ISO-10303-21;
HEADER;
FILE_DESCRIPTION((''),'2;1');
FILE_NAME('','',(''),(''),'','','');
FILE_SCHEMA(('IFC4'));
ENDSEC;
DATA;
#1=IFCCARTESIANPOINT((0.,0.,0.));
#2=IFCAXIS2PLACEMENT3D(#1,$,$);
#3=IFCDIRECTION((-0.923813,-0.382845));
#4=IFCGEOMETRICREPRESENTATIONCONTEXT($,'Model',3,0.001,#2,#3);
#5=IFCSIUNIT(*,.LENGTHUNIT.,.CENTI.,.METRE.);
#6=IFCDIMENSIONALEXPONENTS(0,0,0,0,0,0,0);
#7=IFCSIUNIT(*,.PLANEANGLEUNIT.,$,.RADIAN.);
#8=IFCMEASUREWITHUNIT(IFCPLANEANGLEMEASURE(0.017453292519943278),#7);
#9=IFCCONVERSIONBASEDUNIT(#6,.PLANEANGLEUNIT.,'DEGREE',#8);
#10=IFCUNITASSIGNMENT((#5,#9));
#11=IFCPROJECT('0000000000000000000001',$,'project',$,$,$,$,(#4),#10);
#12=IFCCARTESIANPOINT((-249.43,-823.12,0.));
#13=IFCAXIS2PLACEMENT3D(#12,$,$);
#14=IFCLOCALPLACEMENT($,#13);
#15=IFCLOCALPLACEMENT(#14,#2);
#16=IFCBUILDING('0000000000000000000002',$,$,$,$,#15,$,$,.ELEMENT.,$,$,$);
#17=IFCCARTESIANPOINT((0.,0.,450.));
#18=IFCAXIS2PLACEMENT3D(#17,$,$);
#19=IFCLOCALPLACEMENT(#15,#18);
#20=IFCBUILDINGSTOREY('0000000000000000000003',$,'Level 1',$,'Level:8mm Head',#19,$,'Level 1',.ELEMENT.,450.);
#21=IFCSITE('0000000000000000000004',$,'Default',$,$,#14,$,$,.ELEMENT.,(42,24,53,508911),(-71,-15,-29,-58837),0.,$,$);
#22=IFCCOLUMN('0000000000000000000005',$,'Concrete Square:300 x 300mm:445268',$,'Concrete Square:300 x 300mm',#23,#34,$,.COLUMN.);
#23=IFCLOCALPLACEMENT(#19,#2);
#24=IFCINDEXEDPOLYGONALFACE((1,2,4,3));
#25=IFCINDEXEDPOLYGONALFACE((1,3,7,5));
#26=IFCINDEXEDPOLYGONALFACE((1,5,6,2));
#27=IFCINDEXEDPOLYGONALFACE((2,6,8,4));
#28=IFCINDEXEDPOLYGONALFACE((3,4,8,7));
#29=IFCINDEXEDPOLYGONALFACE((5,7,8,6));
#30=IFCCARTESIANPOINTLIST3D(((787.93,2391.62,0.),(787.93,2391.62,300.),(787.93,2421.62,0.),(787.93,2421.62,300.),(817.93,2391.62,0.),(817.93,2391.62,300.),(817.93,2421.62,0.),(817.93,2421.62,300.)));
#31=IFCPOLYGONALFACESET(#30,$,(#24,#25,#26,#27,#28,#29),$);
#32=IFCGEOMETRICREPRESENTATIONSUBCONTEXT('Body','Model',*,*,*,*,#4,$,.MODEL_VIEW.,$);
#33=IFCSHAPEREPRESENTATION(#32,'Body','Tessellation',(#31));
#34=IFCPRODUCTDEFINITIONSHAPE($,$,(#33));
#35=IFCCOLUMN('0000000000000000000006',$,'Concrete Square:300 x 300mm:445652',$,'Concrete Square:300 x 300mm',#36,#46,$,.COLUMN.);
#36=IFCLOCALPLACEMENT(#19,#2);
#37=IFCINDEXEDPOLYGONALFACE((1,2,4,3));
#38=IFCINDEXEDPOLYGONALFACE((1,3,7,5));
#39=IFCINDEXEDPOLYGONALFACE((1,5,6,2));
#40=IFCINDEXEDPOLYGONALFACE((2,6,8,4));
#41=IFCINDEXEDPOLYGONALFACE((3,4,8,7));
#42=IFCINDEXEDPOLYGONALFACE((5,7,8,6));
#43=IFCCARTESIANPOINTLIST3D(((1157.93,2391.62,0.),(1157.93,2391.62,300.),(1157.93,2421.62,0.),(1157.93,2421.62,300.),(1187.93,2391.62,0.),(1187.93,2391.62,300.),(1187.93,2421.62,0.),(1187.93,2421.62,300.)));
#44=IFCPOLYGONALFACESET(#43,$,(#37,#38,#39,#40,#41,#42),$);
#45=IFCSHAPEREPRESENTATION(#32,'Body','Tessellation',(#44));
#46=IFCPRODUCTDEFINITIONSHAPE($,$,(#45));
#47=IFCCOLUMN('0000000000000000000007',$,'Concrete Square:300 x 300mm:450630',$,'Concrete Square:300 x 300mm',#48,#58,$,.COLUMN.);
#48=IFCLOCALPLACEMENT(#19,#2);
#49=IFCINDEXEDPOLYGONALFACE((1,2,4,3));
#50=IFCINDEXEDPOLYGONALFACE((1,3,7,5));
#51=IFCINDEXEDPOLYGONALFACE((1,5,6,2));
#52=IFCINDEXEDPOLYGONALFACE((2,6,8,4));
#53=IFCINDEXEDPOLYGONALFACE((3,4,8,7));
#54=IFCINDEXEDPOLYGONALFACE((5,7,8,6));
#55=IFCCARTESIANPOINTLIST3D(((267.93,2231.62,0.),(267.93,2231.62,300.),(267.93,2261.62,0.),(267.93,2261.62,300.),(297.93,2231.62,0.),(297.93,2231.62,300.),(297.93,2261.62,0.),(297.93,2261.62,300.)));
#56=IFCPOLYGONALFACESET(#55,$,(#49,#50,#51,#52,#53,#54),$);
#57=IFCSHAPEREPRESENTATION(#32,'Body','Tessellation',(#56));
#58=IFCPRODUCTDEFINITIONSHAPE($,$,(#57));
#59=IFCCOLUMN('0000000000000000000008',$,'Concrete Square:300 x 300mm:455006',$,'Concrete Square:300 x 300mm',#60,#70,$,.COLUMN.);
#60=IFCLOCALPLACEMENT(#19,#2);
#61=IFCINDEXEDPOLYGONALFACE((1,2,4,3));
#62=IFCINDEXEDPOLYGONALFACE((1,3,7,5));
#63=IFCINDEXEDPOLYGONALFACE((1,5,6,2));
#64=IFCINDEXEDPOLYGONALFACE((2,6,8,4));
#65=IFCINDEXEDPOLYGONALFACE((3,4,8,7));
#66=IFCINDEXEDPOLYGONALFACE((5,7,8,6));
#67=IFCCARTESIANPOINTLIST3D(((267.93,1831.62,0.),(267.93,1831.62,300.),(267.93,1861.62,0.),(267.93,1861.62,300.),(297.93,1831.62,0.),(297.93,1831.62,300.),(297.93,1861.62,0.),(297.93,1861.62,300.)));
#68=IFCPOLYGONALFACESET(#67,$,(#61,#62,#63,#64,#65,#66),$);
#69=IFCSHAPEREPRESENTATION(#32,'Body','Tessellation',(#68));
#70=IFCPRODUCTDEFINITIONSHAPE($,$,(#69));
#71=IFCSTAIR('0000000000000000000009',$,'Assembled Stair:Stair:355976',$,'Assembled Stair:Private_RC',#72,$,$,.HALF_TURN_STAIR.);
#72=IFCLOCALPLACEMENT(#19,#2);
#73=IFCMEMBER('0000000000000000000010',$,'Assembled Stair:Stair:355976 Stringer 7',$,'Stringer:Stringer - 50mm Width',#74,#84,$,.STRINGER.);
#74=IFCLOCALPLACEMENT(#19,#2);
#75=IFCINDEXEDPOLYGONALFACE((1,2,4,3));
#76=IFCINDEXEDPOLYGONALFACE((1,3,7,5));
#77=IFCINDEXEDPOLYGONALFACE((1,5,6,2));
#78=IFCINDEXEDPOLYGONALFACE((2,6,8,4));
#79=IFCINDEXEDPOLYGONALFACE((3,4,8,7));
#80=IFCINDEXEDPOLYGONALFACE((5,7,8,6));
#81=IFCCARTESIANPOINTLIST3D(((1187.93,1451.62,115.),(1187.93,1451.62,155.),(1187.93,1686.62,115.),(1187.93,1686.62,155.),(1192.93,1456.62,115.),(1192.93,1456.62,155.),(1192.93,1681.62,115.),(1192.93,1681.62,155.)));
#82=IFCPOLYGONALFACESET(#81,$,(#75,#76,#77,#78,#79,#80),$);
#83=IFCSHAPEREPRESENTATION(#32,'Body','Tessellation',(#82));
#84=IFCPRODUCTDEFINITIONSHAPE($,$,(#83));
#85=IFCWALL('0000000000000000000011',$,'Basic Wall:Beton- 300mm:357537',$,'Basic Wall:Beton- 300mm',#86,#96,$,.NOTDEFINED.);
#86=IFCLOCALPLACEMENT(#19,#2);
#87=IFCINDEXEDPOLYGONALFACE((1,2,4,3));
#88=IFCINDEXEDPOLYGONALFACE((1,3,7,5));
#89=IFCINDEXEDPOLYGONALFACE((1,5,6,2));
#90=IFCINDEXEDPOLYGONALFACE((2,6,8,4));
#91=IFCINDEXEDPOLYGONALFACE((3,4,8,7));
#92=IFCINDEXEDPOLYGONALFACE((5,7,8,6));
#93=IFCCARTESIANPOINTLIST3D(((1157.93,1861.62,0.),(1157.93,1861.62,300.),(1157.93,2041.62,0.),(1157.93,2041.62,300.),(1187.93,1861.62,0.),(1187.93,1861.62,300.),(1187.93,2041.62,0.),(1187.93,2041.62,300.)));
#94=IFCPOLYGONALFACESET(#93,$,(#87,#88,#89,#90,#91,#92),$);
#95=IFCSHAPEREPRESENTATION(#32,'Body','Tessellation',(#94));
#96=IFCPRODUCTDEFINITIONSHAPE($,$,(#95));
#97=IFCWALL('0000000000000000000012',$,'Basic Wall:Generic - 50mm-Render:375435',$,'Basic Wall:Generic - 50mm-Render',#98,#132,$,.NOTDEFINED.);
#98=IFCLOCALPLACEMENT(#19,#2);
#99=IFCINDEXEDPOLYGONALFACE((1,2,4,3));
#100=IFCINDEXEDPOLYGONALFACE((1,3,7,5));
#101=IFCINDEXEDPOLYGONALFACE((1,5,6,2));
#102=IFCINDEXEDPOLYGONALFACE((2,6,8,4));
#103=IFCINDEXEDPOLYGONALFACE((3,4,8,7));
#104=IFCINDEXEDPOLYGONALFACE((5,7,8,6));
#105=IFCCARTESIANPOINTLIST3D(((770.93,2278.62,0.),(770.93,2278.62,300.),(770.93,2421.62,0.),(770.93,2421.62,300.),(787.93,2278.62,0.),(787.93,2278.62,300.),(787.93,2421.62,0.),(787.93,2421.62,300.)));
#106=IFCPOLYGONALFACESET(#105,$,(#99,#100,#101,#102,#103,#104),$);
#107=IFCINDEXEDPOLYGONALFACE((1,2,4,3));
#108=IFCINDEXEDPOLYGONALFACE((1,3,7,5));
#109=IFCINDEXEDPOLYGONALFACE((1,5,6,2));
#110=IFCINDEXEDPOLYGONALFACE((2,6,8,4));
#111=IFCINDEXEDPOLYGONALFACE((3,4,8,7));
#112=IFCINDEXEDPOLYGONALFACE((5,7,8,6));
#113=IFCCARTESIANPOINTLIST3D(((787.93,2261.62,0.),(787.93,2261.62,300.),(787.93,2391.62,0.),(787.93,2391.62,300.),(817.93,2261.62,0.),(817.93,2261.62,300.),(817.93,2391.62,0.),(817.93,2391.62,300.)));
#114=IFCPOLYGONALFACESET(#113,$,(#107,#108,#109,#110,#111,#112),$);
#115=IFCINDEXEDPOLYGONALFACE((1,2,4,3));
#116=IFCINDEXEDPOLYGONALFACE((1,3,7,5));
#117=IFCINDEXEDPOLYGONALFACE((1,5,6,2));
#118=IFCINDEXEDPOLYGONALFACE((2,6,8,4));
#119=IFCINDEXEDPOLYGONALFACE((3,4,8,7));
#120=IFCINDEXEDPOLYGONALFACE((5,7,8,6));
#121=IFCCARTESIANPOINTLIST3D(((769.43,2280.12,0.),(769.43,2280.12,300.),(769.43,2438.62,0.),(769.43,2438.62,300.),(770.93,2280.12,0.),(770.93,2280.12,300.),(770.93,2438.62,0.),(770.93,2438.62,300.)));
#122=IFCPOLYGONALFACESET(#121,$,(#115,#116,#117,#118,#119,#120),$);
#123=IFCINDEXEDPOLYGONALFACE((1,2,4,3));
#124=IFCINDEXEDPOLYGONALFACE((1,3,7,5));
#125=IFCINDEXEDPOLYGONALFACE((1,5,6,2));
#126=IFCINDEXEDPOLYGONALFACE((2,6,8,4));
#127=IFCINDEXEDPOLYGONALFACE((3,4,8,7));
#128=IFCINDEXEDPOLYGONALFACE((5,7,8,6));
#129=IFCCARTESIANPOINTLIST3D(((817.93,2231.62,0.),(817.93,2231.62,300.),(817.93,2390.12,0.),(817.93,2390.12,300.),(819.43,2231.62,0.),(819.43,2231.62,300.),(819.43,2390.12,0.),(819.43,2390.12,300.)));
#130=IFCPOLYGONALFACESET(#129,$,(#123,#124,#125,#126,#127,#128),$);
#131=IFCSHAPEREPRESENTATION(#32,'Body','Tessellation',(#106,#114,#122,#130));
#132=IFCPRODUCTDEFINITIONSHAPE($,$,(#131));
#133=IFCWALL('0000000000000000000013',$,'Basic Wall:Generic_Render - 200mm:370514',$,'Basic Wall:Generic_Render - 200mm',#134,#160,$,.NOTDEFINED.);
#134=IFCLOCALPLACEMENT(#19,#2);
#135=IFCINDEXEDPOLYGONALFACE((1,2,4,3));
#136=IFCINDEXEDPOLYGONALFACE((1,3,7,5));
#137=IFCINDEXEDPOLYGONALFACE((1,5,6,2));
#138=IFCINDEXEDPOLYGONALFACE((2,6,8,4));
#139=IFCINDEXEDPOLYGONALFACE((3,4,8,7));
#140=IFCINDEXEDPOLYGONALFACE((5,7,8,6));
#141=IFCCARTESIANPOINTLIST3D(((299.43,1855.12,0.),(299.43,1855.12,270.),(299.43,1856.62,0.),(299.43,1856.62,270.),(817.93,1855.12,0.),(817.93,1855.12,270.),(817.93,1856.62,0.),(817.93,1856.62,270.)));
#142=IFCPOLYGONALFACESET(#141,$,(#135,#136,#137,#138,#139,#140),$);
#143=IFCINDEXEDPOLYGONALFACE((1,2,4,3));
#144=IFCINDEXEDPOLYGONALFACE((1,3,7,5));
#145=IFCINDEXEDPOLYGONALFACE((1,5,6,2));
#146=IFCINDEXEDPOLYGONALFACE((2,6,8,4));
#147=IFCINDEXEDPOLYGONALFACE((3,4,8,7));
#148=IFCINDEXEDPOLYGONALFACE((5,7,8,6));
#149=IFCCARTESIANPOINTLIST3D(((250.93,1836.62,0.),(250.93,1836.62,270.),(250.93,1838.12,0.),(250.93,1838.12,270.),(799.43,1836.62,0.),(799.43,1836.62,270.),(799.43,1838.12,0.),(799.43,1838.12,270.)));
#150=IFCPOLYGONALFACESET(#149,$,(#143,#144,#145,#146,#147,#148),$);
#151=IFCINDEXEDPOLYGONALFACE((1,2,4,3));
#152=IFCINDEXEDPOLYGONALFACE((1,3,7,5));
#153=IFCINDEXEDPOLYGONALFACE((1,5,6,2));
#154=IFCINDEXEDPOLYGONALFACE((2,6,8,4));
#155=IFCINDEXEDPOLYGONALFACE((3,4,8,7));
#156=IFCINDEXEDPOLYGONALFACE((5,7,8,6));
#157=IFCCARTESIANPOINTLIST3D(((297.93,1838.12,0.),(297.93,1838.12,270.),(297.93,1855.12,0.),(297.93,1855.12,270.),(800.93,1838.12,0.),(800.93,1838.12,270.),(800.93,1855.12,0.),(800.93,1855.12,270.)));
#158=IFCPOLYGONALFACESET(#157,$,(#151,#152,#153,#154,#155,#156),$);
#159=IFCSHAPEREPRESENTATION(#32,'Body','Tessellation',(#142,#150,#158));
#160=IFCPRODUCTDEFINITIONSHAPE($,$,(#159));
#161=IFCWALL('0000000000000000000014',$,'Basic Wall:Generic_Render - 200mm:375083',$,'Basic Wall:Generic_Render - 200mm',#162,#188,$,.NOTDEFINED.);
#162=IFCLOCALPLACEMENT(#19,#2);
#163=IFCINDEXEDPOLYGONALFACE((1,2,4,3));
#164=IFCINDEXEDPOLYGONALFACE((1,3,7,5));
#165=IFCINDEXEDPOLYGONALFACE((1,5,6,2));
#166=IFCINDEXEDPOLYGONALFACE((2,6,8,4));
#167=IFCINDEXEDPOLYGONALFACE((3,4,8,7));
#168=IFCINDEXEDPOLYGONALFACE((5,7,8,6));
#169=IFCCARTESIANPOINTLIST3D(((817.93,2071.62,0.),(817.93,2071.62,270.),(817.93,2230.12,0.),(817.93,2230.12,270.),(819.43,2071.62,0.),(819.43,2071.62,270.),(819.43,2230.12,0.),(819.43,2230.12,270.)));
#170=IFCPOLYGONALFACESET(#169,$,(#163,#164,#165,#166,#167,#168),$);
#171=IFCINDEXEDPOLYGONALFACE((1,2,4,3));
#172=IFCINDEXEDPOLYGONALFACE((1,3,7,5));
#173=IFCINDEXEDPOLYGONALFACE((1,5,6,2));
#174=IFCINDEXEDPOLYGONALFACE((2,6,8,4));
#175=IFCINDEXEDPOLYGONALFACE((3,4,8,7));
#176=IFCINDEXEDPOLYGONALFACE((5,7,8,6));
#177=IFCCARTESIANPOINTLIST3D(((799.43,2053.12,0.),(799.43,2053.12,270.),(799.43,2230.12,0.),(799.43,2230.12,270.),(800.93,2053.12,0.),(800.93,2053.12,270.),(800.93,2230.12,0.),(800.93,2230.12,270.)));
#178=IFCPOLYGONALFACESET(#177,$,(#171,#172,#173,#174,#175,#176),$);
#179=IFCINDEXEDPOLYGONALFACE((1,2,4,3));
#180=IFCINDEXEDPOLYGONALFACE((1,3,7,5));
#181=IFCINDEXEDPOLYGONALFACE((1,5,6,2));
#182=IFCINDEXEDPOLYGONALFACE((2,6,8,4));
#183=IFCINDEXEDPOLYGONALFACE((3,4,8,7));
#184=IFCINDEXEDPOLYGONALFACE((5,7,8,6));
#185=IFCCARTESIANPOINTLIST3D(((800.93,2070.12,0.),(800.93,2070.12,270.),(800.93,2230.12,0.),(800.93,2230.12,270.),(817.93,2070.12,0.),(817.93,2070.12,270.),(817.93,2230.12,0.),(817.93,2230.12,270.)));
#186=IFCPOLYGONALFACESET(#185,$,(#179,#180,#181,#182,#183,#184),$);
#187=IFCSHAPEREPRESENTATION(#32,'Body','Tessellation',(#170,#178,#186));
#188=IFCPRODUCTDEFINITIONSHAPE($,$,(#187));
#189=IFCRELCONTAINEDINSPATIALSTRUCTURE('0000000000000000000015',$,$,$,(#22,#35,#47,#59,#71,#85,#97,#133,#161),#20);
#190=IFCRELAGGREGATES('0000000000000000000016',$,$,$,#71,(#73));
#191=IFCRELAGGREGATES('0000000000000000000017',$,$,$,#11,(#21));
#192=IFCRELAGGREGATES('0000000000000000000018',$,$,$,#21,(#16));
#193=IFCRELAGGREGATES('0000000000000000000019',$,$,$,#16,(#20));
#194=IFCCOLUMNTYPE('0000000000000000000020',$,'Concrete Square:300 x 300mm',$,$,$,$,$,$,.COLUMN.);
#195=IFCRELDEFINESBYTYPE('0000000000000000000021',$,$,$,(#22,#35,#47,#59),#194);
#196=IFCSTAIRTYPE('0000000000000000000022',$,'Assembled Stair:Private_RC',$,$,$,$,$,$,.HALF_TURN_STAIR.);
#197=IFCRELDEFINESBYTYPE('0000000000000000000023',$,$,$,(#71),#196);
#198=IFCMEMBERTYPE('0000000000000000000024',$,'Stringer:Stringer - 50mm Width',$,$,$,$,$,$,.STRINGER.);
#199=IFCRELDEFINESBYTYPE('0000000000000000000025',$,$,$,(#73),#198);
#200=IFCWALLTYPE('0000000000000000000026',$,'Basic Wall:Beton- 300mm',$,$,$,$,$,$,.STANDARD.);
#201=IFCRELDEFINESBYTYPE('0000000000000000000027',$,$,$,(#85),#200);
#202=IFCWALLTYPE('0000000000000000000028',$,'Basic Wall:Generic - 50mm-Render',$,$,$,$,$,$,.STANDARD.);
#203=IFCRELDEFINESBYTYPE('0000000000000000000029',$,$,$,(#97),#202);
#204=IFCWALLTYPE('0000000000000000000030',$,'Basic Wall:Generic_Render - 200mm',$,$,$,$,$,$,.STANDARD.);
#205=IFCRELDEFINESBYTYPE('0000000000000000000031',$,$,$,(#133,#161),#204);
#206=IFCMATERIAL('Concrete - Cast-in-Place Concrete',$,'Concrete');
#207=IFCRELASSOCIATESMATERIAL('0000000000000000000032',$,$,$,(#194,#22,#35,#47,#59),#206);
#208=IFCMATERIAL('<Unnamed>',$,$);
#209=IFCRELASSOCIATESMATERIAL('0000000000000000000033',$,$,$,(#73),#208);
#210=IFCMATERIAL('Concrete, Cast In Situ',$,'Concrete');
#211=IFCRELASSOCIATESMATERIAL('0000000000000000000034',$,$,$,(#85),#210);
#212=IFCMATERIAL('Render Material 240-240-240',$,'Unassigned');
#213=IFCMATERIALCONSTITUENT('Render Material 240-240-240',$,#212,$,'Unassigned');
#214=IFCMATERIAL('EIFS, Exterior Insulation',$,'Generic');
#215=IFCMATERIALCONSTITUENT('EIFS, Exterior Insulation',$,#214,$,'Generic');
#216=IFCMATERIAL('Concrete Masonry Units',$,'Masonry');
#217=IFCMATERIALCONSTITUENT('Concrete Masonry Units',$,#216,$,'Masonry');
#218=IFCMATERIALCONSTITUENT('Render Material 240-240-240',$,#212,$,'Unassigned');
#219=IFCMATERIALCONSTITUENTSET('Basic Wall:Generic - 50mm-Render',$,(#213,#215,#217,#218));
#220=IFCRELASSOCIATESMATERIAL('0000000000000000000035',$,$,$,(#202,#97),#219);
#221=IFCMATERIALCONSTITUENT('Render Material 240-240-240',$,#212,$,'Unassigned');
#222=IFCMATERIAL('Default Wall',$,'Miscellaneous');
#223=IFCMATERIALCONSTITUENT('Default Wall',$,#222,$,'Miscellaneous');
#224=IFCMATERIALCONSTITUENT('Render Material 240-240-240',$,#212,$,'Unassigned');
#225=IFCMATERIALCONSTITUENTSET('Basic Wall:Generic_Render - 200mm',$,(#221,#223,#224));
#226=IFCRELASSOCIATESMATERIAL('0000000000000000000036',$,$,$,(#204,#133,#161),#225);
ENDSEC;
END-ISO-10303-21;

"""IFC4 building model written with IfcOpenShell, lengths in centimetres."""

from ifc_helpers import new_model, entity, si_unit, converted_unit, direction, frame, origin, place, context, subcontext, project, spatial, indexed_curve, outline, extrude, source, transform, mapped, material, constituent, constituent_set, type_object, type_shapes, element, aggregate, save


model = new_model("IFC4")

# Units and contexts
model_context = context("Model", 3, precision=0.001, world=origin(), true_north=direction((-0.923813, -0.382845)))
body_context = subcontext(model_context, "Body", "Model", "MODEL_VIEW")
ifc_project = project(units=[si_unit("LENGTHUNIT", "METRE", prefix="CENTI"), converted_unit("PLANEANGLEUNIT", "DEGREE", entity("IfcPlaneAngleMeasure", 0.017453292519943278), si_unit("PLANEANGLEUNIT", "RADIAN"), dimensions=[0, 0, 0, 0, 0, 0, 0])], contexts=[model_context])

# Site, building, storey
site_placement = place(None, frame((-249.43, -823.12, 0.0)))
site = spatial("IfcSite", under=ifc_project, at=site_placement, Name="Default", CompositionType="ELEMENT", RefLatitude=(42, 24, 53, 508911), RefLongitude=(-71, -15, -29, -58837), RefElevation=0.0)
building_placement = place(site_placement, origin())
building = spatial("IfcBuilding", under=site, at=building_placement, CompositionType="ELEMENT")
storey_placement = place(building_placement, frame((0.0, 0.0, 450.0)))
storey = spatial("IfcBuildingStorey", under=building, at=storey_placement, Name="Level 1", ObjectType="Level:8mm Head", LongName="Level 1", CompositionType="ELEMENT", Elevation=450.0)

# Columns
ifc_material_1 = material(Name="Concrete - Cast-in-Place Concrete", Category="Concrete")
column_type = type_object("IfcColumnType", Name="Concrete Square:300 x 300mm", PredefinedType="COLUMN", material=ifc_material_1)
shared_shape_1 = source(origin(), body_context, "Body", "SweptSolid", [
    extrude(outline(indexed_curve([(-15.0, -15.0), (15.0, -15.0), (15.0, 15.0), (-15.0, 15.0), (-15.0, -15.0)], self_intersect=False)), frame((0.0, 0.0, 450.0), z_axis=(0.0, 0.0, 1.0), x_axis=(-1.0, 0.0, 0.0)), (0.0, 0.0, 1.0), 300.0),
])
type_shapes(column_type, [shared_shape_1])
for number, where, name in (
    (1, (802.93, 2406.62, -450.0), "Concrete Square:300 x 300mm:445268"),
    (2, (1172.93, 2406.62, -450.0), "Concrete Square:300 x 300mm:445652"),
    (3, (282.93, 2246.62, -450.0), "Concrete Square:300 x 300mm:450630"),
    (4, (282.93, 1846.62, -450.0), "Concrete Square:300 x 300mm:455006"),
):
    element("IfcColumn", number, at=place(storey_placement, frame(where)), inside=storey, type_object=column_type, material=ifc_material_1, Name=name, ObjectType="Concrete Square:300 x 300mm", PredefinedType="COLUMN", context=body_context, shape_type="MappedRepresentation", body=[
        mapped(shared_shape_1, transform((0.0, 0.0, 0.0), scale=1.0)),
    ])

# Stair, member
stair_type = type_object("IfcStairType", Name="Assembled Stair:Private_RC", PredefinedType="HALF_TURN_STAIR")
stair_placement = place(storey_placement, origin())
stair = element("IfcStair", 5, at=stair_placement, inside=storey, type_object=stair_type, Name="Assembled Stair:Stair:355976", ObjectType="Assembled Stair:Private_RC", PredefinedType="HALF_TURN_STAIR")
ifc_material_2 = material(Name="<Unnamed>")
member_type = type_object("IfcMemberType", Name="Stringer:Stringer - 50mm Width", PredefinedType="STRINGER")
member_1_placement = place(stair_placement, frame((1187.93, 1451.62, 115.0)))
member_1 = element("IfcMember", 6, at=member_1_placement, type_object=member_type, material=ifc_material_2, Name="Assembled Stair:Stair:355976 Stringer 7", ObjectType="Stringer:Stringer - 50mm Width", PredefinedType="STRINGER", context=body_context, shape_type="SweptSolid", body=[
    extrude(outline(indexed_curve([(-117.5, -2.5), (117.5, -2.5), (112.5, 2.5), (-112.5, 2.5), (-117.5, -2.5)], self_intersect=False)), frame((2.5, 117.5, 0.0), z_axis=(0.0, 0.0, 1.0), x_axis=(0.0, -1.0, 0.0)), (0.0, 0.0, 1.0), 40.0),
])

# Walls
ifc_material_3 = material(Name="Concrete, Cast In Situ", Category="Concrete")
wall_type_1 = type_object("IfcWallType", Name="Basic Wall:Beton- 300mm", PredefinedType="STANDARD")
wall_1_placement = place(storey_placement, frame((1172.93, 2041.62, 0.0), z_axis=(0.0, 0.0, 1.0), x_axis=(0.0, -1.0, 0.0)))
element("IfcWall", 7, at=wall_1_placement, inside=storey, type_object=wall_type_1, material=ifc_material_3, Name="Basic Wall:Beton- 300mm:357537", ObjectType="Basic Wall:Beton- 300mm", PredefinedType="NOTDEFINED", context=body_context, shape_type="SweptSolid", body=[
    extrude(outline(indexed_curve([(180.0, 15.0), (0.0, 15.0), (0.0, -15.0), (180.0, -15.0), (180.0, 15.0)], self_intersect=False)), origin(), (0.0, 0.0, 1.0), 300.0),
])
ifc_material_4 = material(Name="Render Material 240-240-240", Category="Unassigned")
ifc_constituent_1 = constituent(ifc_material_4, Name="Render Material 240-240-240", Category="Unassigned")
ifc_material_5 = material(Name="EIFS, Exterior Insulation", Category="Generic")
ifc_constituent_2 = constituent(ifc_material_5, Name="EIFS, Exterior Insulation", Category="Generic")
ifc_material_6 = material(Name="Concrete Masonry Units", Category="Masonry")
ifc_constituent_3 = constituent(ifc_material_6, Name="Concrete Masonry Units", Category="Masonry")
ifc_constituent_4 = constituent(ifc_material_4, Name="Render Material 240-240-240", Category="Unassigned")
ifc_constituent_set_1 = constituent_set(constituents=[ifc_constituent_1, ifc_constituent_2, ifc_constituent_3, ifc_constituent_4], Name="Basic Wall:Generic - 50mm-Render")
wall_type_2 = type_object("IfcWallType", Name="Basic Wall:Generic - 50mm-Render", PredefinedType="STANDARD", material=ifc_constituent_set_1)
wall_2_placement = place(storey_placement, frame((794.43, 2280.12, 0.0), z_axis=(0.0, 0.0, 1.0), x_axis=(0.0, 1.0, 0.0)))
element("IfcWall", 8, at=wall_2_placement, inside=storey, type_object=wall_type_2, material=ifc_constituent_set_1, Name="Basic Wall:Generic - 50mm-Render:375435", ObjectType="Basic Wall:Generic - 50mm-Render", PredefinedType="NOTDEFINED", context=body_context, shape_type="SweptSolid", body=[
    extrude(outline(indexed_curve([(-8.5, -71.5), (8.5, -71.5), (8.5, 71.5), (-8.5, 71.5), (-8.5, -71.5)], self_intersect=False)), frame((70.0, 15.0, 0.0), z_axis=(0.0, 0.0, 1.0), x_axis=(0.0, -1.0, 0.0)), (0.0, 0.0, 1.0), 300.0),
    extrude(outline(indexed_curve([(-15.0, -65.0), (15.0, -65.0), (15.0, 65.0), (-15.0, 65.0), (-15.0, -65.0)], self_intersect=False)), frame((46.5, -8.5, 0.0), z_axis=(0.0, 0.0, 1.0), x_axis=(0.0, 1.0, 0.0)), (0.0, 0.0, 1.0), 300.0),
    extrude(outline(indexed_curve([(-0.75, -79.25), (0.75, -79.25), (0.75, 79.25), (-0.75, 79.25), (-0.75, -79.25)], self_intersect=False)), frame((79.25, 24.25, 0.0), z_axis=(0.0, 0.0, 1.0), x_axis=(0.0, -1.0, 0.0)), (0.0, 0.0, 1.0), 300.0),
    extrude(outline(indexed_curve([(-0.75, -79.25), (0.75, -79.25), (0.75, 79.25), (-0.75, 79.25), (-0.75, -79.25)], self_intersect=False)), frame((30.75, -24.25, 0.0), z_axis=(0.0, 0.0, 1.0), x_axis=(0.0, -1.0, 0.0)), (0.0, 0.0, 1.0), 300.0),
])

# Shared definitions
ifc_constituent_5 = constituent(ifc_material_4, Name="Render Material 240-240-240", Category="Unassigned")
ifc_material_7 = material(Name="Default Wall", Category="Miscellaneous")
ifc_constituent_6 = constituent(ifc_material_7, Name="Default Wall", Category="Miscellaneous")
ifc_constituent_7 = constituent(ifc_material_4, Name="Render Material 240-240-240", Category="Unassigned")
ifc_constituent_set_2 = constituent_set(constituents=[ifc_constituent_5, ifc_constituent_6, ifc_constituent_7], Name="Basic Wall:Generic_Render - 200mm")
wall_type_3 = type_object("IfcWallType", Name="Basic Wall:Generic_Render - 200mm", PredefinedType="STANDARD", material=ifc_constituent_set_2)

# Wall
wall_3_placement = place(storey_placement, frame((799.43, 1846.62, 0.0), z_axis=(0.0, 0.0, 1.0), x_axis=(-1.0, 0.0, 0.0)))
element("IfcWall", 9, at=wall_3_placement, inside=storey, type_object=wall_type_3, material=ifc_constituent_set_2, Name="Basic Wall:Generic_Render - 200mm:370514", ObjectType="Basic Wall:Generic_Render - 200mm", PredefinedType="NOTDEFINED", context=body_context, shape_type="SweptSolid", body=[
    extrude(outline(indexed_curve([(-0.75, -259.25), (0.75, -259.25), (0.75, 259.25), (-0.75, 259.25), (-0.75, -259.25)], self_intersect=False)), frame((240.75, -9.25, 0.0), z_axis=(0.0, 0.0, 1.0), x_axis=(0.0, 1.0, 0.0)), (0.0, 0.0, 1.0), 270.0),
    extrude(outline(indexed_curve([(-0.75, -274.25), (0.75, -274.25), (0.75, 274.25), (-0.75, 274.25), (-0.75, -274.25)], self_intersect=False)), frame((274.25, 9.25, 0.0), z_axis=(0.0, 0.0, 1.0), x_axis=(0.0, -1.0, 0.0)), (0.0, 0.0, 1.0), 270.0),
    extrude(outline(indexed_curve([(-251.5, -8.5), (251.5, -8.5), (251.5, 8.5), (-251.5, 8.5), (-251.5, -8.5)], self_intersect=False)), frame((250.0, 0.0, 0.0)), (0.0, 0.0, 1.0), 270.0),
])

# Wall
wall_4_placement = place(storey_placement, frame((809.43, 2071.62, 0.0), z_axis=(0.0, 0.0, 1.0), x_axis=(0.0, 1.0, 0.0)))
element("IfcWall", 10, at=wall_4_placement, inside=storey, type_object=wall_type_3, material=ifc_constituent_set_2, Name="Basic Wall:Generic_Render - 200mm:375083", ObjectType="Basic Wall:Generic_Render - 200mm", PredefinedType="NOTDEFINED", context=body_context, shape_type="SweptSolid", body=[
    extrude(outline(indexed_curve([(-0.75, -79.25), (0.75, -79.25), (0.75, 79.25), (-0.75, 79.25), (-0.75, -79.25)], self_intersect=False)), frame((79.25, -9.25, 0.0), z_axis=(0.0, 0.0, 1.0), x_axis=(0.0, 1.0, 0.0)), (0.0, 0.0, 1.0), 270.0),
    extrude(outline(indexed_curve([(-0.75, -88.5), (0.75, -88.5), (0.75, 88.5), (-0.75, 88.5), (-0.75, -88.5)], self_intersect=False)), frame((70.0, 9.25, 0.0), z_axis=(0.0, 0.0, 1.0), x_axis=(0.0, -1.0, 0.0)), (0.0, 0.0, 1.0), 270.0),
    extrude(outline(indexed_curve([(-80.0, -8.5), (80.0, -8.5), (80.0, 8.5), (-80.0, 8.5), (-80.0, -8.5)], self_intersect=False)), frame((78.5, 0.0, 0.0)), (0.0, 0.0, 1.0), 270.0),
])

aggregate(stair, [member_1])

save(model, "model.ifc")
